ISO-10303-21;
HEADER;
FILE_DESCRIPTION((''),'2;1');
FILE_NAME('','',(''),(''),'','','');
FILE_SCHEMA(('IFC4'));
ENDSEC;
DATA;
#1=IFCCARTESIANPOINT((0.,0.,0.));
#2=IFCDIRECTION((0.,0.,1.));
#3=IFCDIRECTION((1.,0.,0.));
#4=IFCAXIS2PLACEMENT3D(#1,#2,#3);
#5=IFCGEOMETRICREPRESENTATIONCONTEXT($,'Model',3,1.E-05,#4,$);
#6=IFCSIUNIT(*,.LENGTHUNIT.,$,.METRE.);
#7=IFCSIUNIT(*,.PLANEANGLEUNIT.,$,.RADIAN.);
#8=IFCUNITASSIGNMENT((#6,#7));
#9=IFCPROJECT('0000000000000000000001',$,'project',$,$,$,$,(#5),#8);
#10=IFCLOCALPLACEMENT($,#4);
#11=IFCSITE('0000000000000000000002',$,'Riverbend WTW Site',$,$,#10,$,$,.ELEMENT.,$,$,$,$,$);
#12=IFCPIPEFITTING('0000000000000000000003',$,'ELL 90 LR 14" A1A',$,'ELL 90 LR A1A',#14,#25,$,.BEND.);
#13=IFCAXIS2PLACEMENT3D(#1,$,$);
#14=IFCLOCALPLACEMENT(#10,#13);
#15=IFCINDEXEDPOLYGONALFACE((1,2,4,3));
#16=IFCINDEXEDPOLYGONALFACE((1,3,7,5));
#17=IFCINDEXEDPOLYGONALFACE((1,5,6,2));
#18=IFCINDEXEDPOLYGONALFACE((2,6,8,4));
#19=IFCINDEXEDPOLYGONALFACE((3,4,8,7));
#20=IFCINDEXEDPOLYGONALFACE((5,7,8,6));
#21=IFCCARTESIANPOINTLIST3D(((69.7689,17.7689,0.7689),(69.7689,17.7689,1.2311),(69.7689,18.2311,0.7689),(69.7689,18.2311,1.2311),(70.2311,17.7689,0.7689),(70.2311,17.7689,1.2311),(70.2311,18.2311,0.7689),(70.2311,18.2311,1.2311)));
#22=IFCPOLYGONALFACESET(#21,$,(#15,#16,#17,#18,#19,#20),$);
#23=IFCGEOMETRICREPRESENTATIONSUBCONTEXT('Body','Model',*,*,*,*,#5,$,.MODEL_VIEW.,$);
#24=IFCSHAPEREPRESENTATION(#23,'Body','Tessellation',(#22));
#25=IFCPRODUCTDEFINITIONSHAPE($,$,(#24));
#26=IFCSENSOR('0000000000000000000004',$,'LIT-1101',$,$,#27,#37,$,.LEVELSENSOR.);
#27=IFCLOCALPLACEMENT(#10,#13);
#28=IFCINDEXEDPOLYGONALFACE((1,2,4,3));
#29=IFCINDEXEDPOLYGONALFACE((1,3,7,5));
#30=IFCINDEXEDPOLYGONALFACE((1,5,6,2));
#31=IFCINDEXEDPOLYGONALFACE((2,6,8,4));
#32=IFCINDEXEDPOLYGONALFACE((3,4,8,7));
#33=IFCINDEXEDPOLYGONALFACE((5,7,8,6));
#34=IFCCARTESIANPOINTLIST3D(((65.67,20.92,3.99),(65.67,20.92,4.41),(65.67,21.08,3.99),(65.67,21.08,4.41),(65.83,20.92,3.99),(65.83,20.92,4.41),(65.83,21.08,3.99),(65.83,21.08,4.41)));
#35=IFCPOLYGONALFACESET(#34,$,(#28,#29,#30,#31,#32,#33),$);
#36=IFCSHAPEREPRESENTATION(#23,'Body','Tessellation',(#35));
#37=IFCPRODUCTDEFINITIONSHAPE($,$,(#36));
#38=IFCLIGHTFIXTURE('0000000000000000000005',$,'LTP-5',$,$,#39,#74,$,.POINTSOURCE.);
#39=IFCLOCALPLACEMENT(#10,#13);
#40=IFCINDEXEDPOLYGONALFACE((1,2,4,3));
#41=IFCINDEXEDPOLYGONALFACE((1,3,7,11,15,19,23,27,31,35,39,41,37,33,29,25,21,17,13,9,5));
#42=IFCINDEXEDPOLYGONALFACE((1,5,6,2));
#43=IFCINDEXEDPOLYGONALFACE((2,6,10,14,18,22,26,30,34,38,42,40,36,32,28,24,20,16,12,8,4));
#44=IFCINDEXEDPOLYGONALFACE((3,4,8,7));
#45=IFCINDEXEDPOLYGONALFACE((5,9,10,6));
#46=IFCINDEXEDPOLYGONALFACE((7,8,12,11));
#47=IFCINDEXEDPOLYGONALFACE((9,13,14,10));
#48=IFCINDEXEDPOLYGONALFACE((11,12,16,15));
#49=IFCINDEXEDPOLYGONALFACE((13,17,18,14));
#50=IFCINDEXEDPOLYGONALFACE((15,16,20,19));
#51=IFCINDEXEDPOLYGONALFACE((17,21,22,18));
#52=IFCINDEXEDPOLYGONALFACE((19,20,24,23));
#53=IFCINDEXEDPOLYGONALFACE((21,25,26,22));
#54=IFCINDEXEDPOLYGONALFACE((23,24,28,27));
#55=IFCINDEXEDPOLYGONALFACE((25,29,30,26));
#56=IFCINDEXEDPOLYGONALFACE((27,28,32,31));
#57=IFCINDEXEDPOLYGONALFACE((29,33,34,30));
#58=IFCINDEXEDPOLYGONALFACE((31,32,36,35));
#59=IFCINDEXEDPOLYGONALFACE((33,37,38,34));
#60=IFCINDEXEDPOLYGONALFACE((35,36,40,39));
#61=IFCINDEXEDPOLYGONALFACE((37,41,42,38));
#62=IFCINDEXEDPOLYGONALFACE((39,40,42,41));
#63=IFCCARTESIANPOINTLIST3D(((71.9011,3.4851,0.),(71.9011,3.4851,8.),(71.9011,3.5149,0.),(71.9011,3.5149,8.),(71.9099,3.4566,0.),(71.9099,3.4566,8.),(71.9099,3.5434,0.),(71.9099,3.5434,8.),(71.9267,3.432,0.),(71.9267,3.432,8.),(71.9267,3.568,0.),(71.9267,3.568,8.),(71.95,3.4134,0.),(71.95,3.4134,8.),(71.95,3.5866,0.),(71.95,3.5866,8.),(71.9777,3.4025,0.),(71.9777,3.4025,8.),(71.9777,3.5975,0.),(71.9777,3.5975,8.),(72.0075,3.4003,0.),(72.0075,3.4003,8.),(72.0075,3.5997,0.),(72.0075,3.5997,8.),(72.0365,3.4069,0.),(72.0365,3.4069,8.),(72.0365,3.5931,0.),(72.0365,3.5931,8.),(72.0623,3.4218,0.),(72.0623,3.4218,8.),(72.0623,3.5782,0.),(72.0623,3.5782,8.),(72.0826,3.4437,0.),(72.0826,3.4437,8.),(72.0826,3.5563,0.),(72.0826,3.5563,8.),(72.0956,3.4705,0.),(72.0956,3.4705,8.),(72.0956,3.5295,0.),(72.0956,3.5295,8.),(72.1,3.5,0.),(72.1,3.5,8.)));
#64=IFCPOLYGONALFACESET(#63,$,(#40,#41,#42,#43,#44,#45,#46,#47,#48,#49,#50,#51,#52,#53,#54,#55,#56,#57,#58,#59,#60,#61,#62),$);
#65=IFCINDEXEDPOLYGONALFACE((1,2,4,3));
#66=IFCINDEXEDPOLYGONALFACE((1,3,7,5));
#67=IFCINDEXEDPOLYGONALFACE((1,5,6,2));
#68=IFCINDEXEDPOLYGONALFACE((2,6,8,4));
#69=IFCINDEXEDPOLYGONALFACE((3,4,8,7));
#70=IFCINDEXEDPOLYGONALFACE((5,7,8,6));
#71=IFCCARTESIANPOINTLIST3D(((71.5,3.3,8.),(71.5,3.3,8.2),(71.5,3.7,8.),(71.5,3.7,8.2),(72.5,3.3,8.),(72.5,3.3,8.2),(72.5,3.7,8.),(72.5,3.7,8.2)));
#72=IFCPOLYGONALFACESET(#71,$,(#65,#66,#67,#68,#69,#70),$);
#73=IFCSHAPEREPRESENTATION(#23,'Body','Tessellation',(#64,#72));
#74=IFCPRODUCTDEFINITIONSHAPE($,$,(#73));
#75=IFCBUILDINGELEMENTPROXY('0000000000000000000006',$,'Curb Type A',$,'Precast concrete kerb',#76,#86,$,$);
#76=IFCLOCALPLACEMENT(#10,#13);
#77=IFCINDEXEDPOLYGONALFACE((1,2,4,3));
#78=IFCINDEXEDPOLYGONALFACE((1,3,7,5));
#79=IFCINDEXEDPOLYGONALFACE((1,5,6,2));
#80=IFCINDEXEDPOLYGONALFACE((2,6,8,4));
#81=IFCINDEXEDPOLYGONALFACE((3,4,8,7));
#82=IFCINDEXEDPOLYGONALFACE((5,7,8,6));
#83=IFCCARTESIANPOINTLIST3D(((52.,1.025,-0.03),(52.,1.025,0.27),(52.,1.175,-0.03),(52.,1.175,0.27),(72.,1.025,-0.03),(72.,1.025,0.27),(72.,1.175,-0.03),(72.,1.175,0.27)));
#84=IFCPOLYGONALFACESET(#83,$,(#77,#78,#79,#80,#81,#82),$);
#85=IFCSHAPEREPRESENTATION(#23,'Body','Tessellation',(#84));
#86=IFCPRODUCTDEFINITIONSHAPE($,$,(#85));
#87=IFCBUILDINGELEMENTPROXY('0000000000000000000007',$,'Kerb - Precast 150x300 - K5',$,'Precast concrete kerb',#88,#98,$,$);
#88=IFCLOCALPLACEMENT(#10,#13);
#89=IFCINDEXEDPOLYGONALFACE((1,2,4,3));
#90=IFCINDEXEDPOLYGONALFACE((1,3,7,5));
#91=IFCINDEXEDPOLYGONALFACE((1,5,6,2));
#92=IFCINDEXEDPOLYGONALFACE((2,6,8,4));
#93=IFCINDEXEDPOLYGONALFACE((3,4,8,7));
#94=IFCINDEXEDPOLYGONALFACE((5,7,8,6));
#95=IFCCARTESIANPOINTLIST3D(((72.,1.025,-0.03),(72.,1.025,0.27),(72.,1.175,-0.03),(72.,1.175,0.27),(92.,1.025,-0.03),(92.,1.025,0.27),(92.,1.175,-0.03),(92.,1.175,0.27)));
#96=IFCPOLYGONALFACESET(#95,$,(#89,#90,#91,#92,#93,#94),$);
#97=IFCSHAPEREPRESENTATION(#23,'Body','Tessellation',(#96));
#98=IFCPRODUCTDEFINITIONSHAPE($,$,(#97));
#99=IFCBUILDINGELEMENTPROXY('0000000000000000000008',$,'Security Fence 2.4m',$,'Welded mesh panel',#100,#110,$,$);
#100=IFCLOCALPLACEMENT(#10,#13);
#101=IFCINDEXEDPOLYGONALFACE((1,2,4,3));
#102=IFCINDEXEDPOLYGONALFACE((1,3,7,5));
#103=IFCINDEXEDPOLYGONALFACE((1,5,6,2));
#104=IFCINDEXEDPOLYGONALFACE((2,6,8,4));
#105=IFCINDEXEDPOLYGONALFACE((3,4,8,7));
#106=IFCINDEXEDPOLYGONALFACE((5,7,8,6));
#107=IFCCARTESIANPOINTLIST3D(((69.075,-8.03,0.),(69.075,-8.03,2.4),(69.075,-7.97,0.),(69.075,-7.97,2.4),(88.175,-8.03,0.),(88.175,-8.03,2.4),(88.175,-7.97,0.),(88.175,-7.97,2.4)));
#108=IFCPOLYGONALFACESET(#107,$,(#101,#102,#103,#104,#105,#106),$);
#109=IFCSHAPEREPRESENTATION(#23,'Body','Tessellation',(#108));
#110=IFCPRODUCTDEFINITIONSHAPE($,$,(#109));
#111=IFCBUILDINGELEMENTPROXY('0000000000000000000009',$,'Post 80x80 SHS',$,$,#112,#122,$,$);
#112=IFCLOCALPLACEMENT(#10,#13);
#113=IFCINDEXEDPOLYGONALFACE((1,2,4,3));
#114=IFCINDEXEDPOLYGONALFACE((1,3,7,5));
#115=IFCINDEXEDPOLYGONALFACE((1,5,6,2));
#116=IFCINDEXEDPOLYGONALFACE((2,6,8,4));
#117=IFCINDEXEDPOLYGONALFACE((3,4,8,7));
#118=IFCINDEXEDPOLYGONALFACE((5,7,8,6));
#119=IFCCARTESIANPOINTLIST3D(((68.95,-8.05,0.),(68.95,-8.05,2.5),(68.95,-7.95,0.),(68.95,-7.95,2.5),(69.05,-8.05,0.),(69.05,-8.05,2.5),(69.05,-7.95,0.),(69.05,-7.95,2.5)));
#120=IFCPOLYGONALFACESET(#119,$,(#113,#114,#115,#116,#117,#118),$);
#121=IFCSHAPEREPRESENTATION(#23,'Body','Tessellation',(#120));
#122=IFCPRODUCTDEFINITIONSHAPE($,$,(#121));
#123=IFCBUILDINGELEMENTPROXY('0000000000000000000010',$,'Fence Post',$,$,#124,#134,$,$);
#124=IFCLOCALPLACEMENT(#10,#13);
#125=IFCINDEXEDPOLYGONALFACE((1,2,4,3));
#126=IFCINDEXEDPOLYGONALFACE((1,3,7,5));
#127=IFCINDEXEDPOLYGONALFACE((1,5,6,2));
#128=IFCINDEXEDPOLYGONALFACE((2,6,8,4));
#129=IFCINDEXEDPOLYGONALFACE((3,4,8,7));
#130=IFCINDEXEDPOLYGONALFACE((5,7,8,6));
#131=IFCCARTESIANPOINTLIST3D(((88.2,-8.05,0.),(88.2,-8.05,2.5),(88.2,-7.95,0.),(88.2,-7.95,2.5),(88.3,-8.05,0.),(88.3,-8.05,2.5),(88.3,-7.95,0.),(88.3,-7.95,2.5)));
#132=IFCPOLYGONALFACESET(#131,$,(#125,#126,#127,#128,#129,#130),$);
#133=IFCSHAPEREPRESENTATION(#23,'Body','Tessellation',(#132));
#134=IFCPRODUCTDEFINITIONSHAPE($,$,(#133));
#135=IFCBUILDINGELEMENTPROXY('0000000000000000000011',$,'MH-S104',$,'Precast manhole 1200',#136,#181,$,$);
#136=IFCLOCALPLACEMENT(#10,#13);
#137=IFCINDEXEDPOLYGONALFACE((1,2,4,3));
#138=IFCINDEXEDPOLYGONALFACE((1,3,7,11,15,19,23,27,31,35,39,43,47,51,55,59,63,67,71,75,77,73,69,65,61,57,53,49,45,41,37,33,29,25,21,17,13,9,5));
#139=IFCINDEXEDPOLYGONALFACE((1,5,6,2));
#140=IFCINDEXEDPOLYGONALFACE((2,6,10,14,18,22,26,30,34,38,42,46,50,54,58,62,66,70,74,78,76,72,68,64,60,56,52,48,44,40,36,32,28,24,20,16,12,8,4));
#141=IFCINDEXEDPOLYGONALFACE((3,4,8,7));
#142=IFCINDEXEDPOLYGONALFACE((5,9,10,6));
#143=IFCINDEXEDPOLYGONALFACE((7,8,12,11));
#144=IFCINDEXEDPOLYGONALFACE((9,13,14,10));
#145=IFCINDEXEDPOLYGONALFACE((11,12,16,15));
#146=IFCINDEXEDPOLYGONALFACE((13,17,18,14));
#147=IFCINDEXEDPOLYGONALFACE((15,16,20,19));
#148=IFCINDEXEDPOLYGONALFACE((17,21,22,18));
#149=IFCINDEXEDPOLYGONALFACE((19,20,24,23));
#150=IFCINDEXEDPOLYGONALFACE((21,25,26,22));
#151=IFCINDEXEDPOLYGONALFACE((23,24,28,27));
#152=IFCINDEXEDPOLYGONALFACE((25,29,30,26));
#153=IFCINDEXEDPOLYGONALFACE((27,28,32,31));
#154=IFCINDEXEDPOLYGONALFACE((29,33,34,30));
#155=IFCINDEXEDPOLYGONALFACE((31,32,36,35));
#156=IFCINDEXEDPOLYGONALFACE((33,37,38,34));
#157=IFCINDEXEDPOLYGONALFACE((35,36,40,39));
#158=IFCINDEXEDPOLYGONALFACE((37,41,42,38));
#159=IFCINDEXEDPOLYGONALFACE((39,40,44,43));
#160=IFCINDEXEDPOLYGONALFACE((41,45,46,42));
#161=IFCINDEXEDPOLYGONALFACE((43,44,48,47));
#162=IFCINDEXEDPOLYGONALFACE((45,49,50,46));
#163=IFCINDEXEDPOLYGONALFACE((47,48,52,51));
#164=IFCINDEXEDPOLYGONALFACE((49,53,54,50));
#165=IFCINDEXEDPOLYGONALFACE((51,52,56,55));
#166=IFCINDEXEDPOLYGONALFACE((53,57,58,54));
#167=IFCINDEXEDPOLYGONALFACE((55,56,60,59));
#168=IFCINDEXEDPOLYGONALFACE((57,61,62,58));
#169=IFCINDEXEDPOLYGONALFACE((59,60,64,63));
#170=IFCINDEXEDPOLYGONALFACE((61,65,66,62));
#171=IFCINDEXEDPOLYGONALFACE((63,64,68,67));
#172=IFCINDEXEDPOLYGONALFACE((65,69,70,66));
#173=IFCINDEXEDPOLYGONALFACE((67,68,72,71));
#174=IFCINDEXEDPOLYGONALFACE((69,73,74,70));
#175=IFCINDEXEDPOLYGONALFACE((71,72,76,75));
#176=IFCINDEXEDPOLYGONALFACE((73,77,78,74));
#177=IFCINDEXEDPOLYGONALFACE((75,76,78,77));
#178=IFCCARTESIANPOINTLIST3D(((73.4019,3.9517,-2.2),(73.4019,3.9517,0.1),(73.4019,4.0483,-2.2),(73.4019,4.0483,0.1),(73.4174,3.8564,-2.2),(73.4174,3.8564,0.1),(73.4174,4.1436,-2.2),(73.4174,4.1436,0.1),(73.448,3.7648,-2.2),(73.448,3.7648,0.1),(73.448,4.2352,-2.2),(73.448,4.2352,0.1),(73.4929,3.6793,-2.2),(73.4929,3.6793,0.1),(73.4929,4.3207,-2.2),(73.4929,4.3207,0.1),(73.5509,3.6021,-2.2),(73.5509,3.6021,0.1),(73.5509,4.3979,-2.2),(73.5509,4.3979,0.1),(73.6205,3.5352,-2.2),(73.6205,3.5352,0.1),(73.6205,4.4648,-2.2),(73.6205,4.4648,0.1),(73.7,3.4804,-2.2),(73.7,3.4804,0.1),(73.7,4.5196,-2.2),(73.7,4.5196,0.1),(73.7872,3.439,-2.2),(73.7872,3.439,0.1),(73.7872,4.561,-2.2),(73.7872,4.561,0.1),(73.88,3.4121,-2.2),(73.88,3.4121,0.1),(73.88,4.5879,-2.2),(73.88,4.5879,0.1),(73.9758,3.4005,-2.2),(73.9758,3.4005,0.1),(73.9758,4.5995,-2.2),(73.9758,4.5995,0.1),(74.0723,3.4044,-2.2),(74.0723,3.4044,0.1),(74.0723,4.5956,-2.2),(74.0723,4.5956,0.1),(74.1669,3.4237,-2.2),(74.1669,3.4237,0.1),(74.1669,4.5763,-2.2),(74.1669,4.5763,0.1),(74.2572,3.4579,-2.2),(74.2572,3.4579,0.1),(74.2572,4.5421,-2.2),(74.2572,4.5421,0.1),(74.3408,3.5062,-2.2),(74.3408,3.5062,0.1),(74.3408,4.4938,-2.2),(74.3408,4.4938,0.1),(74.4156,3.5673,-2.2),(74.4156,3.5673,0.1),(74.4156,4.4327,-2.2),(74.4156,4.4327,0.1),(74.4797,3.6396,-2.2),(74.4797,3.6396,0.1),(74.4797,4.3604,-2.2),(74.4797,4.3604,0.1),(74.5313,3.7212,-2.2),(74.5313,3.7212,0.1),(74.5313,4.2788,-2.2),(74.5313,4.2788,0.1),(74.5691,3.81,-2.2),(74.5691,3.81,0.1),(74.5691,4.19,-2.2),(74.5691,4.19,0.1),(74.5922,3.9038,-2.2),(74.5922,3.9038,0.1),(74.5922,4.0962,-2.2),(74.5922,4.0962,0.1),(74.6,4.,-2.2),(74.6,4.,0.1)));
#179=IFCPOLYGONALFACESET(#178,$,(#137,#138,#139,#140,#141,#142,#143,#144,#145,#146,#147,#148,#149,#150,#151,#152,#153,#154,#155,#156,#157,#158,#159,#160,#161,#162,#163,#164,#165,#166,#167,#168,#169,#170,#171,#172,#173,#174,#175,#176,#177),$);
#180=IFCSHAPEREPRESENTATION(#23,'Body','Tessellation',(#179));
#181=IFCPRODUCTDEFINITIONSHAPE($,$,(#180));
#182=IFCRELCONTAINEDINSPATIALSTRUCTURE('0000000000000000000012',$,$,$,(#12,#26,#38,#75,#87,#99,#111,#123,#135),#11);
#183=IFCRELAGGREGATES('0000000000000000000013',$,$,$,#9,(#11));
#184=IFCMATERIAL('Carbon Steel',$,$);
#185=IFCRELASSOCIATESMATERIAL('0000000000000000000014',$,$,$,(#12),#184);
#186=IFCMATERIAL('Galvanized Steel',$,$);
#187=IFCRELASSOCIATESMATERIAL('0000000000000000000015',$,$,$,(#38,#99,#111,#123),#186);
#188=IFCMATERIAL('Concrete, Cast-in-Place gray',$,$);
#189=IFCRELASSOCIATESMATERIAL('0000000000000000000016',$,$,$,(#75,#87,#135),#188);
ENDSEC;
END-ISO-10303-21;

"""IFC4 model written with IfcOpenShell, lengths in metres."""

from ifc_helpers import new_model, si_unit, frame, origin_with_axes, origin_2d, place, context, subcontext, project, spatial, rectangle, circle, extrude, material, element, save


model = new_model("IFC4")

# Units and contexts
model_context = context("Model", 3, precision=1e-05, world=origin_with_axes())
body_context = subcontext(model_context, "Body", "Model", "MODEL_VIEW")
ifc_project = project(units=[si_unit("LENGTHUNIT", "METRE"), si_unit("PLANEANGLEUNIT", "RADIAN")], contexts=[model_context])

# Site
site_placement = place(None, origin_with_axes())
site = spatial("IfcSite", under=ifc_project, at=site_placement, Name="Riverbend WTW Site", CompositionType="ELEMENT")

# Shared definitions
ifc_material_1 = material(Name="Concrete, Cast-in-Place gray")

# Shared definitions
ifc_material_2 = material(Name="Carbon Steel")

# Pipe fitting
pipe_fitting_placement = place(None, frame((70.0, 18.0, 1.0), z_axis=(0.0, 0.0, 1.0), x_axis=(1.0, 0.0, 0.0)))
element("IfcPipeFitting", 1, at=pipe_fitting_placement, inside=site, material=ifc_material_2, Name="ELL 90 LR 14\" A1A", ObjectType="ELL 90 LR A1A", PredefinedType="BEND", context=body_context, shape_type="SweptSolid", body=[
    extrude(rectangle(XDim=0.4623, YDim=0.4623, at=origin_2d()), frame((0.0, 0.0, -0.2311), z_axis=(0.0, 0.0, 1.0), x_axis=(1.0, 0.0, 0.0)), (0.0, 0.0, 1.0), 0.4623),
])

# Sensor
sensor_placement = place(None, frame((65.75, 21.0, 4.2), z_axis=(0.0, 0.0, 1.0), x_axis=(1.0, 0.0, 0.0)))
element("IfcSensor", 2, at=sensor_placement, inside=site, Name="LIT-1101", PredefinedType="LEVELSENSOR", context=body_context, shape_type="SweptSolid", body=[
    extrude(rectangle(XDim=0.16, YDim=0.16, at=origin_2d()), frame((0.0, 0.0, -0.21), z_axis=(0.0, 0.0, 1.0), x_axis=(1.0, 0.0, 0.0)), (0.0, 0.0, 1.0), 0.42),
])

# Light fixture
ifc_material_3 = material(Name="Galvanized Steel")
light_fixture_placement = place(None, frame((72.0, 3.5, 0.0), z_axis=(0.0, 0.0, 1.0), x_axis=(1.0, 0.0, 0.0)))
element("IfcLightFixture", 3, at=light_fixture_placement, inside=site, material=ifc_material_3, Name="LTP-5", PredefinedType="POINTSOURCE", context=body_context, shape_type="SweptSolid", body=[
    extrude(circle(Radius=0.1, at=origin_2d()), origin_with_axes(), (0.0, 0.0, 1.0), 8.0),
    extrude(rectangle(XDim=1.0, YDim=0.4, at=origin_2d()), frame((0.0, 0.0, 8.0), z_axis=(0.0, 0.0, 1.0), x_axis=(1.0, 0.0, 0.0)), (0.0, 0.0, 1.0), 0.2),
])

# Building element proxies
for number, where, z_axis, x_axis, name in (
    (4, (62.0, 1.1, 0.12), (0.0, 0.0, 1.0), (1.0, 0.0, 0.0), "Curb Type A"),
    (5, (82.0, 1.1, 0.12), (0.0, 0.0, 1.0), (1.0, 0.0, 0.0), "Kerb - Precast 150x300 - K5"),
):
    element("IfcBuildingElementProxy", number, at=place(None, frame(where, z_axis=z_axis, x_axis=x_axis)), inside=site, material=ifc_material_1, Name=name, ObjectType="Precast concrete kerb", context=body_context, shape_type="SweptSolid", body=[
        extrude(rectangle(XDim=20.0, YDim=0.15, at=origin_2d()), frame((0.0, 0.0, -0.15), z_axis=(0.0, 0.0, 1.0), x_axis=(1.0, 0.0, 0.0)), (0.0, 0.0, 1.0), 0.3),
    ])
proxy_1_placement = place(None, frame((78.625, -8.0, 1.2), z_axis=(0.0, 0.0, 1.0), x_axis=(1.0, 0.0, 0.0)))
element("IfcBuildingElementProxy", 6, at=proxy_1_placement, inside=site, material=ifc_material_3, Name="Security Fence 2.4m", ObjectType="Welded mesh panel", context=body_context, shape_type="SweptSolid", body=[
    extrude(rectangle(XDim=19.1, YDim=0.06, at=origin_2d()), frame((0.0, 0.0, -1.2), z_axis=(0.0, 0.0, 1.0), x_axis=(1.0, 0.0, 0.0)), (0.0, 0.0, 1.0), 2.4),
])
for number, where, z_axis, x_axis, name in (
    (7, (69.0, -8.0, 1.25), (0.0, 0.0, 1.0), (1.0, 0.0, 0.0), "Post 80x80 SHS"),
    (8, (88.25, -8.0, 1.25), (0.0, 0.0, 1.0), (1.0, 0.0, 0.0), "Fence Post"),
):
    element("IfcBuildingElementProxy", number, at=place(None, frame(where, z_axis=z_axis, x_axis=x_axis)), inside=site, material=ifc_material_3, Name=name, context=body_context, shape_type="SweptSolid", body=[
        extrude(rectangle(XDim=0.1, YDim=0.1, at=origin_2d()), frame((0.0, 0.0, -1.25), z_axis=(0.0, 0.0, 1.0), x_axis=(1.0, 0.0, 0.0)), (0.0, 0.0, 1.0), 2.5),
    ])
for number, where, z_axis, x_axis, name in (
    (9, (74.0, 4.0, -2.2), (0.0, 0.0, 1.0), (1.0, 0.0, 0.0), "MH-S104"),
):
    element("IfcBuildingElementProxy", number, at=place(None, frame(where, z_axis=z_axis, x_axis=x_axis)), inside=site, material=ifc_material_1, Name=name, ObjectType="Precast manhole 1200", context=body_context, shape_type="SweptSolid", body=[
        extrude(circle(Radius=0.6, at=origin_2d()), origin_with_axes(), (0.0, 0.0, 1.0), 2.3),
    ])

save(model, "model.ifc")
